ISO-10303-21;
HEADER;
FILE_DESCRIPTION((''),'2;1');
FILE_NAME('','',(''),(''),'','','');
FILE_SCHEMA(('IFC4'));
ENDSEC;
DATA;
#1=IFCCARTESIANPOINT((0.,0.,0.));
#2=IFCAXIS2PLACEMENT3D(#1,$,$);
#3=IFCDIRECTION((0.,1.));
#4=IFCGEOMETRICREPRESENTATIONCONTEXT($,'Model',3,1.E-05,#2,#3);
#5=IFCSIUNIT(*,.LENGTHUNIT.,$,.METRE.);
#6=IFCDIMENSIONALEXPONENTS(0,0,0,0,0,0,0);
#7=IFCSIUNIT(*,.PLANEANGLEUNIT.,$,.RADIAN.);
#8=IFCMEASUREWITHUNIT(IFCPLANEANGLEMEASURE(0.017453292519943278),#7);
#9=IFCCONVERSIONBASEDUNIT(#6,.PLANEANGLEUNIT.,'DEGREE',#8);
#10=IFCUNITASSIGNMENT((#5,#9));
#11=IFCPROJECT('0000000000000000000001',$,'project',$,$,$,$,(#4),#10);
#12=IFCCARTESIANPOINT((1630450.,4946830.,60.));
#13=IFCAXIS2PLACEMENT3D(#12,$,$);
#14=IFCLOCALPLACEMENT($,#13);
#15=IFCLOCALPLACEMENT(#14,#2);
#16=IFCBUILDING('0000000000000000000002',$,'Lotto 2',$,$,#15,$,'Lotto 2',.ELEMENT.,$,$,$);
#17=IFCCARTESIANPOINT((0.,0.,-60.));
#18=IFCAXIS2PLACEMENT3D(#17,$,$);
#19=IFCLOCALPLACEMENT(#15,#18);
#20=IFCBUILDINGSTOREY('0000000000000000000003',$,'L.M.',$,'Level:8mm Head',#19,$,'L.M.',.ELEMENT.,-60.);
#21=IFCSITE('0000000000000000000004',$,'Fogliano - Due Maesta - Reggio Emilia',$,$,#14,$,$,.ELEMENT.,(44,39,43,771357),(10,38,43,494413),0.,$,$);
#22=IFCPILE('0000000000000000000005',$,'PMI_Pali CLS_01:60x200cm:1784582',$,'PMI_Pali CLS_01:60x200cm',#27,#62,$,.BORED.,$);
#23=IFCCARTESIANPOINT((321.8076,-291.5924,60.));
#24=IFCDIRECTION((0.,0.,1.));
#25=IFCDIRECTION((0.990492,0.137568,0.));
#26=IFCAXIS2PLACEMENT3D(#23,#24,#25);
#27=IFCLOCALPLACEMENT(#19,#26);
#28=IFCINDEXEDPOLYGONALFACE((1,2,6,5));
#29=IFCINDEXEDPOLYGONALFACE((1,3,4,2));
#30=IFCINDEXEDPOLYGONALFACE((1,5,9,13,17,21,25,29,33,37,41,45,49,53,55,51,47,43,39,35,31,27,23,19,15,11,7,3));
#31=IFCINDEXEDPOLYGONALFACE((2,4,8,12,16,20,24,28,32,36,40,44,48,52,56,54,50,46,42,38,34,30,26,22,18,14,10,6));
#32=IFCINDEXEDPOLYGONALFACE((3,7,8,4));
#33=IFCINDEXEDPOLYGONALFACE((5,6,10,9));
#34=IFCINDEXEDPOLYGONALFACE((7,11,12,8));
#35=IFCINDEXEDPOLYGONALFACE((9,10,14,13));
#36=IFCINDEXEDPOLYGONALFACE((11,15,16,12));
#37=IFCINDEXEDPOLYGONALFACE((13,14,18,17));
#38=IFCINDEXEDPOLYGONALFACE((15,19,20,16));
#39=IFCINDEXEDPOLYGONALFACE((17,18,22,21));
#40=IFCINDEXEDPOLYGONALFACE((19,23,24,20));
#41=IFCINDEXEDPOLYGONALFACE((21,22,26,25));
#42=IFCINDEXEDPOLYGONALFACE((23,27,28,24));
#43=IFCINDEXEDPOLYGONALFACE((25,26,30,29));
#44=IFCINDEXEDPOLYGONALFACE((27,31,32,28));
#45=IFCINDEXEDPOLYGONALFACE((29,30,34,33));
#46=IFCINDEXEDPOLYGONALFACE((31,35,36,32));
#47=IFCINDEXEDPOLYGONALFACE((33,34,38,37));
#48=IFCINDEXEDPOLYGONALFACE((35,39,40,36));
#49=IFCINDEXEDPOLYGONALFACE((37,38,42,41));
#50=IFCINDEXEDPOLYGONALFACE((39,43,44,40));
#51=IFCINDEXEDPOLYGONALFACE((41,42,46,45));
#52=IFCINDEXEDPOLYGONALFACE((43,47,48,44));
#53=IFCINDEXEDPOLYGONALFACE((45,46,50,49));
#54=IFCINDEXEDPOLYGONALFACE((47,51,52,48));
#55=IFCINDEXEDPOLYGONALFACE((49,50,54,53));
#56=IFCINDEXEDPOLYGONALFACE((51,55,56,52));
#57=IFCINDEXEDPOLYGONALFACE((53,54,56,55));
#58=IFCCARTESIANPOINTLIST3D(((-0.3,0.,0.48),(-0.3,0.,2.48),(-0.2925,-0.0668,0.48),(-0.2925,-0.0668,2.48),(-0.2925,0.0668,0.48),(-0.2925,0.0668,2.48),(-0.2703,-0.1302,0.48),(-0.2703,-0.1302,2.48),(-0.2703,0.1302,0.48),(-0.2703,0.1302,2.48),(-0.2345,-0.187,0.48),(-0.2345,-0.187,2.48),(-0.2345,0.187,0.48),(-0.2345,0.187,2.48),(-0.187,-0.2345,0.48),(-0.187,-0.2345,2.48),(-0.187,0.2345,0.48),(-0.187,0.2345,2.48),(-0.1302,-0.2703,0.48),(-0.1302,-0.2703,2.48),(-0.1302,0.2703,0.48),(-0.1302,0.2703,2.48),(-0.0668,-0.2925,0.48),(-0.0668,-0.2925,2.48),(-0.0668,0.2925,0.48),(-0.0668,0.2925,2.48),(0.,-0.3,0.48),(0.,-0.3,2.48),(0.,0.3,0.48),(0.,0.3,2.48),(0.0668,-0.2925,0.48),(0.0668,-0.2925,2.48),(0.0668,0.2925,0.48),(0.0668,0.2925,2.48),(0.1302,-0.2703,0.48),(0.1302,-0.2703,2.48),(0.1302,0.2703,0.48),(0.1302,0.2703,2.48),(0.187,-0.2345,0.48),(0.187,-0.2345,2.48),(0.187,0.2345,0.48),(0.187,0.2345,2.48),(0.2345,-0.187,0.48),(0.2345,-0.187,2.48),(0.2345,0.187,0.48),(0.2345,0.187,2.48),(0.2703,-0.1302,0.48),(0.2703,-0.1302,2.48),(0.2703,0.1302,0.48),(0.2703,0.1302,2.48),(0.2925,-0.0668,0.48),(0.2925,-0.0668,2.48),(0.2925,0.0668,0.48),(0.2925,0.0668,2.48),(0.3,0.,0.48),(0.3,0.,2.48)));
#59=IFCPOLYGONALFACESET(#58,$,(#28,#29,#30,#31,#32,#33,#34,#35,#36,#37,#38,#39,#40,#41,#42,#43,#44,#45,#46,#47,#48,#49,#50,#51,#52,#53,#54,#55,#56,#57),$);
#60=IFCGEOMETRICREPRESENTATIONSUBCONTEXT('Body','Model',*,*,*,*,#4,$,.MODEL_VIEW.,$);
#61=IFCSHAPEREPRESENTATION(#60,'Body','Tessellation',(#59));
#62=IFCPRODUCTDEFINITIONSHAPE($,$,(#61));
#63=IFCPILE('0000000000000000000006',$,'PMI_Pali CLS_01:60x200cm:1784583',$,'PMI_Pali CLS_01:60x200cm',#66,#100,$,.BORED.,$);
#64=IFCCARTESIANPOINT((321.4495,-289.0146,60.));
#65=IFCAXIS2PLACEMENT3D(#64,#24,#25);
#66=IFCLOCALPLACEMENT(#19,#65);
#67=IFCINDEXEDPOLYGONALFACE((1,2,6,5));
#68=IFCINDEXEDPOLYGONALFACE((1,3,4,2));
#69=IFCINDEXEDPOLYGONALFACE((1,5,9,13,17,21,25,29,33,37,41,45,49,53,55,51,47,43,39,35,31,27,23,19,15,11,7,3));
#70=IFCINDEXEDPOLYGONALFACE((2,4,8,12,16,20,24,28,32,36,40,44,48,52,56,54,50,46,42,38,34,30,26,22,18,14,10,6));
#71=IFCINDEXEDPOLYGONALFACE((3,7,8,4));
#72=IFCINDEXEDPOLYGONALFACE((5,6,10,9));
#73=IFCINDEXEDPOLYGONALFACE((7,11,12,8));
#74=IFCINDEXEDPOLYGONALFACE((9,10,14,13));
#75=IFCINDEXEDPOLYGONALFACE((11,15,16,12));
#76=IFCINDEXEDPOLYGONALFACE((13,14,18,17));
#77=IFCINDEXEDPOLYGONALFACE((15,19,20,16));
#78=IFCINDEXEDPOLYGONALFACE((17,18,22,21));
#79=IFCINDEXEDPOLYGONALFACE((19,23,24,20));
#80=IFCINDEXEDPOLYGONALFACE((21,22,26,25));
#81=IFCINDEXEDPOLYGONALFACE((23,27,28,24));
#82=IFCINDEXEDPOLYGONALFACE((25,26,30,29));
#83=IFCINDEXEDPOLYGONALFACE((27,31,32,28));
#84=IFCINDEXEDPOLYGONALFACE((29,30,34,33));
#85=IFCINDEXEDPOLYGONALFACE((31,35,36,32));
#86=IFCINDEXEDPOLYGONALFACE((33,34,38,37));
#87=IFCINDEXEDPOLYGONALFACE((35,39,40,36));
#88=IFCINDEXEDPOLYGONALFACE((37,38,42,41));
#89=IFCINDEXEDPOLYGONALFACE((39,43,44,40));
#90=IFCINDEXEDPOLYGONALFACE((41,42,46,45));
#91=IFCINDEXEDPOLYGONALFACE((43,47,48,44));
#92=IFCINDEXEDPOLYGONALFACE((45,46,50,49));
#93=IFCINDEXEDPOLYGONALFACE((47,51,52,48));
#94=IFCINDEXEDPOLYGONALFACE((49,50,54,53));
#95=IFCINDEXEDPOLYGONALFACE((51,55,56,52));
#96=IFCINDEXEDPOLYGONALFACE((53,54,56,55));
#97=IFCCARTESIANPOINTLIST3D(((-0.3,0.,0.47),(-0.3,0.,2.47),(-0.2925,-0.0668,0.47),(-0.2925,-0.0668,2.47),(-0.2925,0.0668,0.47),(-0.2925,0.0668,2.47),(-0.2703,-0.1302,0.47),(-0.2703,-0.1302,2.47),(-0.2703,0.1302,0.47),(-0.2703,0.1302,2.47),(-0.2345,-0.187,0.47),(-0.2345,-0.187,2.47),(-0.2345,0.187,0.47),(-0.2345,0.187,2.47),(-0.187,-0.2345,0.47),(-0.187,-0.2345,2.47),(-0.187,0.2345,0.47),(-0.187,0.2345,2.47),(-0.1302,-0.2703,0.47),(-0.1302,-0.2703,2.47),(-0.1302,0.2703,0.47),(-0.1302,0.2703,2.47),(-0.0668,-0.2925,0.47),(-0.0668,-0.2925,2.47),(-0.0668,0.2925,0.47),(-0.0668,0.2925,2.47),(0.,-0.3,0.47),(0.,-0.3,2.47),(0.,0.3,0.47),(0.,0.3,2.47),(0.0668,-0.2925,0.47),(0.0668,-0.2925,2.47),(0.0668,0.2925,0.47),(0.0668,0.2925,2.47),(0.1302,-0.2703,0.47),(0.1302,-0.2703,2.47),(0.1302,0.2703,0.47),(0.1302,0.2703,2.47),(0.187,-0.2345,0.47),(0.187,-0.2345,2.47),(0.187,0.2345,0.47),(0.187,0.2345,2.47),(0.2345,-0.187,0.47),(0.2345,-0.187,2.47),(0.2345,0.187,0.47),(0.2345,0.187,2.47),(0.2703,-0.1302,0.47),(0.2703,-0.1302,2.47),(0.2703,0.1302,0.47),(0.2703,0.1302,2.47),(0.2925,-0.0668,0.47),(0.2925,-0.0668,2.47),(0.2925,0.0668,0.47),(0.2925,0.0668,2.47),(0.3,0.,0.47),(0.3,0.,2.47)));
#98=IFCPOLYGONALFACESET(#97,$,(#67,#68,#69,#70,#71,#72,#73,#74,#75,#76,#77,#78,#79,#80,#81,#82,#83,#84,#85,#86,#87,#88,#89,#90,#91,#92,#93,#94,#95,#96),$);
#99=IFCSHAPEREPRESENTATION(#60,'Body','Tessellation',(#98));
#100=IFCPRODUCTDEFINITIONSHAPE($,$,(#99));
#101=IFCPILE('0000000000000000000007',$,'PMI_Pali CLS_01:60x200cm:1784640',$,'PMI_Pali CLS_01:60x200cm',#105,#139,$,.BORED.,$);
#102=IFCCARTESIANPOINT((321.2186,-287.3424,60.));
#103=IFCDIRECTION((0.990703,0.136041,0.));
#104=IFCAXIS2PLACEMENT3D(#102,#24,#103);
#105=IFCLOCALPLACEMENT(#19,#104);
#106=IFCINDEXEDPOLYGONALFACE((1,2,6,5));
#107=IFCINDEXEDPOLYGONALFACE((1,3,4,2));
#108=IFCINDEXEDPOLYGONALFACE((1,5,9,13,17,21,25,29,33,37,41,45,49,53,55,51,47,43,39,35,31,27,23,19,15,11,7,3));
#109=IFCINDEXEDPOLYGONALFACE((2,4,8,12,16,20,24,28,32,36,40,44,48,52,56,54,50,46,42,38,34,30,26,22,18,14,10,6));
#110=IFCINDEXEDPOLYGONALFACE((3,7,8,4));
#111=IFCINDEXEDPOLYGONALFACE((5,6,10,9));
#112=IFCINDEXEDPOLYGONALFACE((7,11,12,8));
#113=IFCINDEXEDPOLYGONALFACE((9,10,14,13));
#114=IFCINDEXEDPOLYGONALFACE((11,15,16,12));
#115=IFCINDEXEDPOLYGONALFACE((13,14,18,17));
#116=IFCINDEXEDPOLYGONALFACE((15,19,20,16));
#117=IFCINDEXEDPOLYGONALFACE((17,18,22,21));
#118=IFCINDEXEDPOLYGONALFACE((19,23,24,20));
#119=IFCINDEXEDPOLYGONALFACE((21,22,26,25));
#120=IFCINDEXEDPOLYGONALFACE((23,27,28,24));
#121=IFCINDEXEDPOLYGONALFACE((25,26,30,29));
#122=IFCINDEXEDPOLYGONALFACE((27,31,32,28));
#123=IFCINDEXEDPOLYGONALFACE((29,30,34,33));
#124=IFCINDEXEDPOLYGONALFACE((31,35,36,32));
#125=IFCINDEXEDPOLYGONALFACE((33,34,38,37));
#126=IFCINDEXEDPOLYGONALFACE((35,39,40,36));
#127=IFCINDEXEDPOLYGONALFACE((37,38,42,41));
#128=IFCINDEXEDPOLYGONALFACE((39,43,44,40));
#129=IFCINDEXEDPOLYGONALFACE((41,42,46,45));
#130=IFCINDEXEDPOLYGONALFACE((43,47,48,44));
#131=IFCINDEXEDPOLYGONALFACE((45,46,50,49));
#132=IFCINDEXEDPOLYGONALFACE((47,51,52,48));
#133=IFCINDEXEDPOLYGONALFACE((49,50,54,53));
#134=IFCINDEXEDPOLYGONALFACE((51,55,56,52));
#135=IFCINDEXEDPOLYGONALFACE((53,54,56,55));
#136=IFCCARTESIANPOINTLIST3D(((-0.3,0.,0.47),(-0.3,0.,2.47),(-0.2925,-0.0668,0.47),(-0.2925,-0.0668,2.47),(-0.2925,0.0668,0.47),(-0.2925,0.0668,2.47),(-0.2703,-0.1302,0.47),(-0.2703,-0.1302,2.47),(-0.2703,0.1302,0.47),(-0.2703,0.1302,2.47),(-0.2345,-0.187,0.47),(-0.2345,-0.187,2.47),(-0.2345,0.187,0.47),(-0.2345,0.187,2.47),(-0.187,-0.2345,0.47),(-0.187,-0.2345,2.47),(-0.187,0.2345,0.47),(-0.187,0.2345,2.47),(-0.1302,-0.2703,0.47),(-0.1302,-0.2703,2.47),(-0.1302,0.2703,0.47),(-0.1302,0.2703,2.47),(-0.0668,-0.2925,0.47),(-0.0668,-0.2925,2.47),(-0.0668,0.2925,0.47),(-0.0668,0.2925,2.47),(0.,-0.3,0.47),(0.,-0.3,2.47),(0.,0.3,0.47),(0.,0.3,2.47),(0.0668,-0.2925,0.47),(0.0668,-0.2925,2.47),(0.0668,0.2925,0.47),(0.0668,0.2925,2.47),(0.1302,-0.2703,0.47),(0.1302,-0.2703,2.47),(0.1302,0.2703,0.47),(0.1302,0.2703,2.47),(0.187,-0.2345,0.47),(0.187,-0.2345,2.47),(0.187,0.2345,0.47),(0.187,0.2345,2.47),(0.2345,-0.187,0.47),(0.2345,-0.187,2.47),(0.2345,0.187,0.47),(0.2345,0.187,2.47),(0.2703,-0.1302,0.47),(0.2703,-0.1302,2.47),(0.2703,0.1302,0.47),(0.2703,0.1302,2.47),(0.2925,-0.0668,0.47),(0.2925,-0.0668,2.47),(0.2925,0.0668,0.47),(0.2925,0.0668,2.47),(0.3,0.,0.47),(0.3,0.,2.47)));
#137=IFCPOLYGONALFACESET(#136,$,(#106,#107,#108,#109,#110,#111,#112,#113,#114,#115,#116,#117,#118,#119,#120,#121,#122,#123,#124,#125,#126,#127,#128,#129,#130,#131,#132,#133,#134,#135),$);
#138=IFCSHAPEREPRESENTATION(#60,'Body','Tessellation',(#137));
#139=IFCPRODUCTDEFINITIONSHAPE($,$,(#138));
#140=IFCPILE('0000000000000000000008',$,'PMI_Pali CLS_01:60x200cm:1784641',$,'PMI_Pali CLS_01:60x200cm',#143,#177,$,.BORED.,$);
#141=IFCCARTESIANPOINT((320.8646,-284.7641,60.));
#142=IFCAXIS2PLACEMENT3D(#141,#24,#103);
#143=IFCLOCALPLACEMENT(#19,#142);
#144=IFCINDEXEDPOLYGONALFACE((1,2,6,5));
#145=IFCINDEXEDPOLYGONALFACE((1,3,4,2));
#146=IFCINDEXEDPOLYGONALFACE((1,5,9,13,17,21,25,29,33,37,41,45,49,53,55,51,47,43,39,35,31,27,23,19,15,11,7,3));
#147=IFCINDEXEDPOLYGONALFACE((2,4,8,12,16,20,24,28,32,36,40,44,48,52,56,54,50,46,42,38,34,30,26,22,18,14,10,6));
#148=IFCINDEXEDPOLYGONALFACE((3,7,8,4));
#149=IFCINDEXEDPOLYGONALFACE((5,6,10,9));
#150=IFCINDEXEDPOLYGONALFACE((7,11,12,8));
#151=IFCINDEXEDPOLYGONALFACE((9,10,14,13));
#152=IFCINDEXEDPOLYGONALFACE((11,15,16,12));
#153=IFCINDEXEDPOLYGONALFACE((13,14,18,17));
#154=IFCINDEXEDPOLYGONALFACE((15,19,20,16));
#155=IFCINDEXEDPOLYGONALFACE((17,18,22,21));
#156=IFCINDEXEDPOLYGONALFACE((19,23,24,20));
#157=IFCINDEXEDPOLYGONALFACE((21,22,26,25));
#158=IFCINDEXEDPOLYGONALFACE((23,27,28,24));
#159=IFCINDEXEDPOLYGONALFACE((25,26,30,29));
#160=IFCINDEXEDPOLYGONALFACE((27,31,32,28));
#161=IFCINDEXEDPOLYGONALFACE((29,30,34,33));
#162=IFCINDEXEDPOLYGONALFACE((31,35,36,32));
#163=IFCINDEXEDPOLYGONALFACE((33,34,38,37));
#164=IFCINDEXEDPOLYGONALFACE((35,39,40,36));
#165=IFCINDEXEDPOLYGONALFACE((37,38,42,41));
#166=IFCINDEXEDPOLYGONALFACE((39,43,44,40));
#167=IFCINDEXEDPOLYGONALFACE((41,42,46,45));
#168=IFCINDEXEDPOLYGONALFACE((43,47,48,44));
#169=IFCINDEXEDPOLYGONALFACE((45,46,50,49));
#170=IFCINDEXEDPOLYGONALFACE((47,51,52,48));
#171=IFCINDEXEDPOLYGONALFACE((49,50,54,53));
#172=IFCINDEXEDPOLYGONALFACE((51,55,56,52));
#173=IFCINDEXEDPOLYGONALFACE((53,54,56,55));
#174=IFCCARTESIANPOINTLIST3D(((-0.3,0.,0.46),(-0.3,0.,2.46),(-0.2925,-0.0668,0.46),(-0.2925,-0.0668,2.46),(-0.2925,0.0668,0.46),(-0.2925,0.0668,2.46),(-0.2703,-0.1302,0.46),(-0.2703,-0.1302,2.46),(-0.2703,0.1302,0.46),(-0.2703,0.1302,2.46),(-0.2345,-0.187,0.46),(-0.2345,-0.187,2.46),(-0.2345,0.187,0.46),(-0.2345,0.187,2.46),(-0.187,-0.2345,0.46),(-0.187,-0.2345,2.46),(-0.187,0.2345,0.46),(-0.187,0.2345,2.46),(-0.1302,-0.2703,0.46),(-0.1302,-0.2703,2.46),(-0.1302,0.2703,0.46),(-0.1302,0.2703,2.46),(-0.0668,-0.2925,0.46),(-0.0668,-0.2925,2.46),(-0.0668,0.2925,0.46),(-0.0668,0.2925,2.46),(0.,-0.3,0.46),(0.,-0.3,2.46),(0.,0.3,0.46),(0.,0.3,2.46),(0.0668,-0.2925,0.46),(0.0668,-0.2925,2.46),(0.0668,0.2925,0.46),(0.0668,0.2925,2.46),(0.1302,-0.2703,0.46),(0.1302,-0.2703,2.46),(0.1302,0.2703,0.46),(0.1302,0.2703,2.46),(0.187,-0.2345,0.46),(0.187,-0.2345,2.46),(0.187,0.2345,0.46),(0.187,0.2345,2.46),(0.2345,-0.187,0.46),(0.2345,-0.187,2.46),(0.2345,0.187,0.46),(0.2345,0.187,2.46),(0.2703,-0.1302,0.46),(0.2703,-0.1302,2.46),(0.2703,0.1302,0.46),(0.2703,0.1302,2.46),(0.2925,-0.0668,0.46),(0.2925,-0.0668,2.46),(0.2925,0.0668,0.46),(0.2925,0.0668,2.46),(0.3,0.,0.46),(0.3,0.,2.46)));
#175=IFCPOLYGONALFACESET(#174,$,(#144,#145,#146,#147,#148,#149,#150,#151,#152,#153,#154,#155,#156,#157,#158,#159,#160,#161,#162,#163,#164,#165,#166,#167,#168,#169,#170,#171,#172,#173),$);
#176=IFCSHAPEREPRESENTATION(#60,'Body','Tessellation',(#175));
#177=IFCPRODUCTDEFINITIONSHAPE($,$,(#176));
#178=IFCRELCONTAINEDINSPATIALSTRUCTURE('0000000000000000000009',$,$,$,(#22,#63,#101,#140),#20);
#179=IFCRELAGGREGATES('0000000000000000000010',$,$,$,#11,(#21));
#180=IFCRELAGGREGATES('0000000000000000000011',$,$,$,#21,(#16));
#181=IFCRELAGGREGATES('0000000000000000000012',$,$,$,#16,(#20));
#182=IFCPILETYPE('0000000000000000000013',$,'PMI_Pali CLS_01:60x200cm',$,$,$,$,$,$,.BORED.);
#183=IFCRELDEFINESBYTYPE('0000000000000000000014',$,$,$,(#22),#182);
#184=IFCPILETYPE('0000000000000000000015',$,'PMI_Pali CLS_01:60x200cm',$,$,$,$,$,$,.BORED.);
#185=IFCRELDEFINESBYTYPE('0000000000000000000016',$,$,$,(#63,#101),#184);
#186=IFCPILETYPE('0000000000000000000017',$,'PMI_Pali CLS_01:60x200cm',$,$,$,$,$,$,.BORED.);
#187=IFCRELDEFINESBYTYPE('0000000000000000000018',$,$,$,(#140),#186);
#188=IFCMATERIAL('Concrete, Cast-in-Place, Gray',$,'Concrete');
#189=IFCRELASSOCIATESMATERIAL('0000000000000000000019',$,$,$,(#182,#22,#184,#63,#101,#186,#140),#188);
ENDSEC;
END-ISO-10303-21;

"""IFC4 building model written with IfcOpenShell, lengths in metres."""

from ifc_helpers import new_model, entity, si_unit, converted_unit, direction, frame, origin, place, context, subcontext, project, spatial, arc, indexed_curve, outline, extrude, source, transform, mapped, material, type_object, type_shapes, element, save


model = new_model("IFC4")

# Units and contexts
model_context = context("Model", 3, precision=1e-05, world=origin(), true_north=direction((0.0, 1.0)))
body_context = subcontext(model_context, "Body", "Model", "MODEL_VIEW")
ifc_project = project(units=[si_unit("LENGTHUNIT", "METRE"), converted_unit("PLANEANGLEUNIT", "DEGREE", entity("IfcPlaneAngleMeasure", 0.017453292519943278), si_unit("PLANEANGLEUNIT", "RADIAN"), dimensions=[0, 0, 0, 0, 0, 0, 0])], contexts=[model_context])

# Site, building, storey
site_placement = place(None, frame((1630450.0, 4946830.0, 60.0)))
site = spatial("IfcSite", under=ifc_project, at=site_placement, Name="Fogliano - Due Maesta - Reggio Emilia", CompositionType="ELEMENT", RefLatitude=(44, 39, 43, 771357), RefLongitude=(10, 38, 43, 494413), RefElevation=0.0)
building_placement = place(site_placement, origin())
building = spatial("IfcBuilding", under=site, at=building_placement, Name="Lotto 2", LongName="Lotto 2", CompositionType="ELEMENT")
storey_placement = place(building_placement, frame((0.0, 0.0, -60.0)))
storey = spatial("IfcBuildingStorey", under=building, at=storey_placement, Name="L.M.", ObjectType="Level:8mm Head", LongName="L.M.", CompositionType="ELEMENT", Elevation=-60.0)

# Piles
ifc_material_1 = material(Name="Concrete, Cast-in-Place, Gray", Category="Concrete")
pile_type_1 = type_object("IfcPileType", Name="PMI_Pali CLS_01:60x200cm", PredefinedType="BORED", material=ifc_material_1)
shared_shape_1 = source(origin(), body_context, "Body", "SweptSolid", [
    extrude(outline(indexed_curve([(-0.3, 0.0), (0.0, -0.3), (0.3, 0.0), (0.0, 0.3)], segments=[arc(1, 2, 3), arc(3, 4, 1)], self_intersect=False)), frame((0.0, 0.0, 0.48)), (0.0, 0.0, 1.0), 2.0),
])
type_shapes(pile_type_1, [shared_shape_1])
pile_1_placement = place(storey_placement, frame((321.8076, -291.5924, 60.0), z_axis=(0.0, 0.0, 1.0), x_axis=(0.990492, 0.137568, 0.0)))
element("IfcPile", 1, at=pile_1_placement, inside=storey, type_object=pile_type_1, material=ifc_material_1, Name="PMI_Pali CLS_01:60x200cm:1784582", ObjectType="PMI_Pali CLS_01:60x200cm", PredefinedType="BORED", context=body_context, shape_type="MappedRepresentation", body=[
    mapped(shared_shape_1, transform((0.0, 0.0, 0.0), scale=1.0)),
])
pile_type_2 = type_object("IfcPileType", Name="PMI_Pali CLS_01:60x200cm", PredefinedType="BORED", material=ifc_material_1)
shared_shape_2 = source(origin(), body_context, "Body", "SweptSolid", [
    extrude(outline(indexed_curve([(-0.3, 0.0), (0.0, -0.3), (0.3, 0.0), (0.0, 0.3)], segments=[arc(1, 2, 3), arc(3, 4, 1)], self_intersect=False)), frame((0.0, 0.0, 0.47)), (0.0, 0.0, 1.0), 2.0),
])
type_shapes(pile_type_2, [shared_shape_2])
for number, where, z_axis, x_axis, name in (
    (2, (321.4495, -289.0146, 60.0), (0.0, 0.0, 1.0), (0.990492, 0.137568, 0.0), "PMI_Pali CLS_01:60x200cm:1784583"),
    (3, (321.2186, -287.3424, 60.0), (0.0, 0.0, 1.0), (0.990703, 0.136041, 0.0), "PMI_Pali CLS_01:60x200cm:1784640"),
):
    element("IfcPile", number, at=place(storey_placement, frame(where, z_axis=z_axis, x_axis=x_axis)), inside=storey, type_object=pile_type_2, material=ifc_material_1, Name=name, ObjectType="PMI_Pali CLS_01:60x200cm", PredefinedType="BORED", context=body_context, shape_type="MappedRepresentation", body=[
        mapped(shared_shape_2, transform((0.0, 0.0, 0.0), scale=1.0)),
    ])
pile_type_3 = type_object("IfcPileType", Name="PMI_Pali CLS_01:60x200cm", PredefinedType="BORED", material=ifc_material_1)
shared_shape_3 = source(origin(), body_context, "Body", "SweptSolid", [
    extrude(outline(indexed_curve([(-0.3, 0.0), (0.0, -0.3), (0.3, 0.0), (0.0, 0.3)], segments=[arc(1, 2, 3), arc(3, 4, 1)], self_intersect=False)), frame((0.0, 0.0, 0.46)), (0.0, 0.0, 1.0), 2.0),
])
type_shapes(pile_type_3, [shared_shape_3])
pile_2_placement = place(storey_placement, frame((320.8646, -284.7641, 60.0), z_axis=(0.0, 0.0, 1.0), x_axis=(0.990703, 0.136041, 0.0)))
element("IfcPile", 4, at=pile_2_placement, inside=storey, type_object=pile_type_3, material=ifc_material_1, Name="PMI_Pali CLS_01:60x200cm:1784641", ObjectType="PMI_Pali CLS_01:60x200cm", PredefinedType="BORED", context=body_context, shape_type="MappedRepresentation", body=[
    mapped(shared_shape_3, transform((0.0, 0.0, 0.0), scale=1.0)),
])

save(model, "model.ifc")
